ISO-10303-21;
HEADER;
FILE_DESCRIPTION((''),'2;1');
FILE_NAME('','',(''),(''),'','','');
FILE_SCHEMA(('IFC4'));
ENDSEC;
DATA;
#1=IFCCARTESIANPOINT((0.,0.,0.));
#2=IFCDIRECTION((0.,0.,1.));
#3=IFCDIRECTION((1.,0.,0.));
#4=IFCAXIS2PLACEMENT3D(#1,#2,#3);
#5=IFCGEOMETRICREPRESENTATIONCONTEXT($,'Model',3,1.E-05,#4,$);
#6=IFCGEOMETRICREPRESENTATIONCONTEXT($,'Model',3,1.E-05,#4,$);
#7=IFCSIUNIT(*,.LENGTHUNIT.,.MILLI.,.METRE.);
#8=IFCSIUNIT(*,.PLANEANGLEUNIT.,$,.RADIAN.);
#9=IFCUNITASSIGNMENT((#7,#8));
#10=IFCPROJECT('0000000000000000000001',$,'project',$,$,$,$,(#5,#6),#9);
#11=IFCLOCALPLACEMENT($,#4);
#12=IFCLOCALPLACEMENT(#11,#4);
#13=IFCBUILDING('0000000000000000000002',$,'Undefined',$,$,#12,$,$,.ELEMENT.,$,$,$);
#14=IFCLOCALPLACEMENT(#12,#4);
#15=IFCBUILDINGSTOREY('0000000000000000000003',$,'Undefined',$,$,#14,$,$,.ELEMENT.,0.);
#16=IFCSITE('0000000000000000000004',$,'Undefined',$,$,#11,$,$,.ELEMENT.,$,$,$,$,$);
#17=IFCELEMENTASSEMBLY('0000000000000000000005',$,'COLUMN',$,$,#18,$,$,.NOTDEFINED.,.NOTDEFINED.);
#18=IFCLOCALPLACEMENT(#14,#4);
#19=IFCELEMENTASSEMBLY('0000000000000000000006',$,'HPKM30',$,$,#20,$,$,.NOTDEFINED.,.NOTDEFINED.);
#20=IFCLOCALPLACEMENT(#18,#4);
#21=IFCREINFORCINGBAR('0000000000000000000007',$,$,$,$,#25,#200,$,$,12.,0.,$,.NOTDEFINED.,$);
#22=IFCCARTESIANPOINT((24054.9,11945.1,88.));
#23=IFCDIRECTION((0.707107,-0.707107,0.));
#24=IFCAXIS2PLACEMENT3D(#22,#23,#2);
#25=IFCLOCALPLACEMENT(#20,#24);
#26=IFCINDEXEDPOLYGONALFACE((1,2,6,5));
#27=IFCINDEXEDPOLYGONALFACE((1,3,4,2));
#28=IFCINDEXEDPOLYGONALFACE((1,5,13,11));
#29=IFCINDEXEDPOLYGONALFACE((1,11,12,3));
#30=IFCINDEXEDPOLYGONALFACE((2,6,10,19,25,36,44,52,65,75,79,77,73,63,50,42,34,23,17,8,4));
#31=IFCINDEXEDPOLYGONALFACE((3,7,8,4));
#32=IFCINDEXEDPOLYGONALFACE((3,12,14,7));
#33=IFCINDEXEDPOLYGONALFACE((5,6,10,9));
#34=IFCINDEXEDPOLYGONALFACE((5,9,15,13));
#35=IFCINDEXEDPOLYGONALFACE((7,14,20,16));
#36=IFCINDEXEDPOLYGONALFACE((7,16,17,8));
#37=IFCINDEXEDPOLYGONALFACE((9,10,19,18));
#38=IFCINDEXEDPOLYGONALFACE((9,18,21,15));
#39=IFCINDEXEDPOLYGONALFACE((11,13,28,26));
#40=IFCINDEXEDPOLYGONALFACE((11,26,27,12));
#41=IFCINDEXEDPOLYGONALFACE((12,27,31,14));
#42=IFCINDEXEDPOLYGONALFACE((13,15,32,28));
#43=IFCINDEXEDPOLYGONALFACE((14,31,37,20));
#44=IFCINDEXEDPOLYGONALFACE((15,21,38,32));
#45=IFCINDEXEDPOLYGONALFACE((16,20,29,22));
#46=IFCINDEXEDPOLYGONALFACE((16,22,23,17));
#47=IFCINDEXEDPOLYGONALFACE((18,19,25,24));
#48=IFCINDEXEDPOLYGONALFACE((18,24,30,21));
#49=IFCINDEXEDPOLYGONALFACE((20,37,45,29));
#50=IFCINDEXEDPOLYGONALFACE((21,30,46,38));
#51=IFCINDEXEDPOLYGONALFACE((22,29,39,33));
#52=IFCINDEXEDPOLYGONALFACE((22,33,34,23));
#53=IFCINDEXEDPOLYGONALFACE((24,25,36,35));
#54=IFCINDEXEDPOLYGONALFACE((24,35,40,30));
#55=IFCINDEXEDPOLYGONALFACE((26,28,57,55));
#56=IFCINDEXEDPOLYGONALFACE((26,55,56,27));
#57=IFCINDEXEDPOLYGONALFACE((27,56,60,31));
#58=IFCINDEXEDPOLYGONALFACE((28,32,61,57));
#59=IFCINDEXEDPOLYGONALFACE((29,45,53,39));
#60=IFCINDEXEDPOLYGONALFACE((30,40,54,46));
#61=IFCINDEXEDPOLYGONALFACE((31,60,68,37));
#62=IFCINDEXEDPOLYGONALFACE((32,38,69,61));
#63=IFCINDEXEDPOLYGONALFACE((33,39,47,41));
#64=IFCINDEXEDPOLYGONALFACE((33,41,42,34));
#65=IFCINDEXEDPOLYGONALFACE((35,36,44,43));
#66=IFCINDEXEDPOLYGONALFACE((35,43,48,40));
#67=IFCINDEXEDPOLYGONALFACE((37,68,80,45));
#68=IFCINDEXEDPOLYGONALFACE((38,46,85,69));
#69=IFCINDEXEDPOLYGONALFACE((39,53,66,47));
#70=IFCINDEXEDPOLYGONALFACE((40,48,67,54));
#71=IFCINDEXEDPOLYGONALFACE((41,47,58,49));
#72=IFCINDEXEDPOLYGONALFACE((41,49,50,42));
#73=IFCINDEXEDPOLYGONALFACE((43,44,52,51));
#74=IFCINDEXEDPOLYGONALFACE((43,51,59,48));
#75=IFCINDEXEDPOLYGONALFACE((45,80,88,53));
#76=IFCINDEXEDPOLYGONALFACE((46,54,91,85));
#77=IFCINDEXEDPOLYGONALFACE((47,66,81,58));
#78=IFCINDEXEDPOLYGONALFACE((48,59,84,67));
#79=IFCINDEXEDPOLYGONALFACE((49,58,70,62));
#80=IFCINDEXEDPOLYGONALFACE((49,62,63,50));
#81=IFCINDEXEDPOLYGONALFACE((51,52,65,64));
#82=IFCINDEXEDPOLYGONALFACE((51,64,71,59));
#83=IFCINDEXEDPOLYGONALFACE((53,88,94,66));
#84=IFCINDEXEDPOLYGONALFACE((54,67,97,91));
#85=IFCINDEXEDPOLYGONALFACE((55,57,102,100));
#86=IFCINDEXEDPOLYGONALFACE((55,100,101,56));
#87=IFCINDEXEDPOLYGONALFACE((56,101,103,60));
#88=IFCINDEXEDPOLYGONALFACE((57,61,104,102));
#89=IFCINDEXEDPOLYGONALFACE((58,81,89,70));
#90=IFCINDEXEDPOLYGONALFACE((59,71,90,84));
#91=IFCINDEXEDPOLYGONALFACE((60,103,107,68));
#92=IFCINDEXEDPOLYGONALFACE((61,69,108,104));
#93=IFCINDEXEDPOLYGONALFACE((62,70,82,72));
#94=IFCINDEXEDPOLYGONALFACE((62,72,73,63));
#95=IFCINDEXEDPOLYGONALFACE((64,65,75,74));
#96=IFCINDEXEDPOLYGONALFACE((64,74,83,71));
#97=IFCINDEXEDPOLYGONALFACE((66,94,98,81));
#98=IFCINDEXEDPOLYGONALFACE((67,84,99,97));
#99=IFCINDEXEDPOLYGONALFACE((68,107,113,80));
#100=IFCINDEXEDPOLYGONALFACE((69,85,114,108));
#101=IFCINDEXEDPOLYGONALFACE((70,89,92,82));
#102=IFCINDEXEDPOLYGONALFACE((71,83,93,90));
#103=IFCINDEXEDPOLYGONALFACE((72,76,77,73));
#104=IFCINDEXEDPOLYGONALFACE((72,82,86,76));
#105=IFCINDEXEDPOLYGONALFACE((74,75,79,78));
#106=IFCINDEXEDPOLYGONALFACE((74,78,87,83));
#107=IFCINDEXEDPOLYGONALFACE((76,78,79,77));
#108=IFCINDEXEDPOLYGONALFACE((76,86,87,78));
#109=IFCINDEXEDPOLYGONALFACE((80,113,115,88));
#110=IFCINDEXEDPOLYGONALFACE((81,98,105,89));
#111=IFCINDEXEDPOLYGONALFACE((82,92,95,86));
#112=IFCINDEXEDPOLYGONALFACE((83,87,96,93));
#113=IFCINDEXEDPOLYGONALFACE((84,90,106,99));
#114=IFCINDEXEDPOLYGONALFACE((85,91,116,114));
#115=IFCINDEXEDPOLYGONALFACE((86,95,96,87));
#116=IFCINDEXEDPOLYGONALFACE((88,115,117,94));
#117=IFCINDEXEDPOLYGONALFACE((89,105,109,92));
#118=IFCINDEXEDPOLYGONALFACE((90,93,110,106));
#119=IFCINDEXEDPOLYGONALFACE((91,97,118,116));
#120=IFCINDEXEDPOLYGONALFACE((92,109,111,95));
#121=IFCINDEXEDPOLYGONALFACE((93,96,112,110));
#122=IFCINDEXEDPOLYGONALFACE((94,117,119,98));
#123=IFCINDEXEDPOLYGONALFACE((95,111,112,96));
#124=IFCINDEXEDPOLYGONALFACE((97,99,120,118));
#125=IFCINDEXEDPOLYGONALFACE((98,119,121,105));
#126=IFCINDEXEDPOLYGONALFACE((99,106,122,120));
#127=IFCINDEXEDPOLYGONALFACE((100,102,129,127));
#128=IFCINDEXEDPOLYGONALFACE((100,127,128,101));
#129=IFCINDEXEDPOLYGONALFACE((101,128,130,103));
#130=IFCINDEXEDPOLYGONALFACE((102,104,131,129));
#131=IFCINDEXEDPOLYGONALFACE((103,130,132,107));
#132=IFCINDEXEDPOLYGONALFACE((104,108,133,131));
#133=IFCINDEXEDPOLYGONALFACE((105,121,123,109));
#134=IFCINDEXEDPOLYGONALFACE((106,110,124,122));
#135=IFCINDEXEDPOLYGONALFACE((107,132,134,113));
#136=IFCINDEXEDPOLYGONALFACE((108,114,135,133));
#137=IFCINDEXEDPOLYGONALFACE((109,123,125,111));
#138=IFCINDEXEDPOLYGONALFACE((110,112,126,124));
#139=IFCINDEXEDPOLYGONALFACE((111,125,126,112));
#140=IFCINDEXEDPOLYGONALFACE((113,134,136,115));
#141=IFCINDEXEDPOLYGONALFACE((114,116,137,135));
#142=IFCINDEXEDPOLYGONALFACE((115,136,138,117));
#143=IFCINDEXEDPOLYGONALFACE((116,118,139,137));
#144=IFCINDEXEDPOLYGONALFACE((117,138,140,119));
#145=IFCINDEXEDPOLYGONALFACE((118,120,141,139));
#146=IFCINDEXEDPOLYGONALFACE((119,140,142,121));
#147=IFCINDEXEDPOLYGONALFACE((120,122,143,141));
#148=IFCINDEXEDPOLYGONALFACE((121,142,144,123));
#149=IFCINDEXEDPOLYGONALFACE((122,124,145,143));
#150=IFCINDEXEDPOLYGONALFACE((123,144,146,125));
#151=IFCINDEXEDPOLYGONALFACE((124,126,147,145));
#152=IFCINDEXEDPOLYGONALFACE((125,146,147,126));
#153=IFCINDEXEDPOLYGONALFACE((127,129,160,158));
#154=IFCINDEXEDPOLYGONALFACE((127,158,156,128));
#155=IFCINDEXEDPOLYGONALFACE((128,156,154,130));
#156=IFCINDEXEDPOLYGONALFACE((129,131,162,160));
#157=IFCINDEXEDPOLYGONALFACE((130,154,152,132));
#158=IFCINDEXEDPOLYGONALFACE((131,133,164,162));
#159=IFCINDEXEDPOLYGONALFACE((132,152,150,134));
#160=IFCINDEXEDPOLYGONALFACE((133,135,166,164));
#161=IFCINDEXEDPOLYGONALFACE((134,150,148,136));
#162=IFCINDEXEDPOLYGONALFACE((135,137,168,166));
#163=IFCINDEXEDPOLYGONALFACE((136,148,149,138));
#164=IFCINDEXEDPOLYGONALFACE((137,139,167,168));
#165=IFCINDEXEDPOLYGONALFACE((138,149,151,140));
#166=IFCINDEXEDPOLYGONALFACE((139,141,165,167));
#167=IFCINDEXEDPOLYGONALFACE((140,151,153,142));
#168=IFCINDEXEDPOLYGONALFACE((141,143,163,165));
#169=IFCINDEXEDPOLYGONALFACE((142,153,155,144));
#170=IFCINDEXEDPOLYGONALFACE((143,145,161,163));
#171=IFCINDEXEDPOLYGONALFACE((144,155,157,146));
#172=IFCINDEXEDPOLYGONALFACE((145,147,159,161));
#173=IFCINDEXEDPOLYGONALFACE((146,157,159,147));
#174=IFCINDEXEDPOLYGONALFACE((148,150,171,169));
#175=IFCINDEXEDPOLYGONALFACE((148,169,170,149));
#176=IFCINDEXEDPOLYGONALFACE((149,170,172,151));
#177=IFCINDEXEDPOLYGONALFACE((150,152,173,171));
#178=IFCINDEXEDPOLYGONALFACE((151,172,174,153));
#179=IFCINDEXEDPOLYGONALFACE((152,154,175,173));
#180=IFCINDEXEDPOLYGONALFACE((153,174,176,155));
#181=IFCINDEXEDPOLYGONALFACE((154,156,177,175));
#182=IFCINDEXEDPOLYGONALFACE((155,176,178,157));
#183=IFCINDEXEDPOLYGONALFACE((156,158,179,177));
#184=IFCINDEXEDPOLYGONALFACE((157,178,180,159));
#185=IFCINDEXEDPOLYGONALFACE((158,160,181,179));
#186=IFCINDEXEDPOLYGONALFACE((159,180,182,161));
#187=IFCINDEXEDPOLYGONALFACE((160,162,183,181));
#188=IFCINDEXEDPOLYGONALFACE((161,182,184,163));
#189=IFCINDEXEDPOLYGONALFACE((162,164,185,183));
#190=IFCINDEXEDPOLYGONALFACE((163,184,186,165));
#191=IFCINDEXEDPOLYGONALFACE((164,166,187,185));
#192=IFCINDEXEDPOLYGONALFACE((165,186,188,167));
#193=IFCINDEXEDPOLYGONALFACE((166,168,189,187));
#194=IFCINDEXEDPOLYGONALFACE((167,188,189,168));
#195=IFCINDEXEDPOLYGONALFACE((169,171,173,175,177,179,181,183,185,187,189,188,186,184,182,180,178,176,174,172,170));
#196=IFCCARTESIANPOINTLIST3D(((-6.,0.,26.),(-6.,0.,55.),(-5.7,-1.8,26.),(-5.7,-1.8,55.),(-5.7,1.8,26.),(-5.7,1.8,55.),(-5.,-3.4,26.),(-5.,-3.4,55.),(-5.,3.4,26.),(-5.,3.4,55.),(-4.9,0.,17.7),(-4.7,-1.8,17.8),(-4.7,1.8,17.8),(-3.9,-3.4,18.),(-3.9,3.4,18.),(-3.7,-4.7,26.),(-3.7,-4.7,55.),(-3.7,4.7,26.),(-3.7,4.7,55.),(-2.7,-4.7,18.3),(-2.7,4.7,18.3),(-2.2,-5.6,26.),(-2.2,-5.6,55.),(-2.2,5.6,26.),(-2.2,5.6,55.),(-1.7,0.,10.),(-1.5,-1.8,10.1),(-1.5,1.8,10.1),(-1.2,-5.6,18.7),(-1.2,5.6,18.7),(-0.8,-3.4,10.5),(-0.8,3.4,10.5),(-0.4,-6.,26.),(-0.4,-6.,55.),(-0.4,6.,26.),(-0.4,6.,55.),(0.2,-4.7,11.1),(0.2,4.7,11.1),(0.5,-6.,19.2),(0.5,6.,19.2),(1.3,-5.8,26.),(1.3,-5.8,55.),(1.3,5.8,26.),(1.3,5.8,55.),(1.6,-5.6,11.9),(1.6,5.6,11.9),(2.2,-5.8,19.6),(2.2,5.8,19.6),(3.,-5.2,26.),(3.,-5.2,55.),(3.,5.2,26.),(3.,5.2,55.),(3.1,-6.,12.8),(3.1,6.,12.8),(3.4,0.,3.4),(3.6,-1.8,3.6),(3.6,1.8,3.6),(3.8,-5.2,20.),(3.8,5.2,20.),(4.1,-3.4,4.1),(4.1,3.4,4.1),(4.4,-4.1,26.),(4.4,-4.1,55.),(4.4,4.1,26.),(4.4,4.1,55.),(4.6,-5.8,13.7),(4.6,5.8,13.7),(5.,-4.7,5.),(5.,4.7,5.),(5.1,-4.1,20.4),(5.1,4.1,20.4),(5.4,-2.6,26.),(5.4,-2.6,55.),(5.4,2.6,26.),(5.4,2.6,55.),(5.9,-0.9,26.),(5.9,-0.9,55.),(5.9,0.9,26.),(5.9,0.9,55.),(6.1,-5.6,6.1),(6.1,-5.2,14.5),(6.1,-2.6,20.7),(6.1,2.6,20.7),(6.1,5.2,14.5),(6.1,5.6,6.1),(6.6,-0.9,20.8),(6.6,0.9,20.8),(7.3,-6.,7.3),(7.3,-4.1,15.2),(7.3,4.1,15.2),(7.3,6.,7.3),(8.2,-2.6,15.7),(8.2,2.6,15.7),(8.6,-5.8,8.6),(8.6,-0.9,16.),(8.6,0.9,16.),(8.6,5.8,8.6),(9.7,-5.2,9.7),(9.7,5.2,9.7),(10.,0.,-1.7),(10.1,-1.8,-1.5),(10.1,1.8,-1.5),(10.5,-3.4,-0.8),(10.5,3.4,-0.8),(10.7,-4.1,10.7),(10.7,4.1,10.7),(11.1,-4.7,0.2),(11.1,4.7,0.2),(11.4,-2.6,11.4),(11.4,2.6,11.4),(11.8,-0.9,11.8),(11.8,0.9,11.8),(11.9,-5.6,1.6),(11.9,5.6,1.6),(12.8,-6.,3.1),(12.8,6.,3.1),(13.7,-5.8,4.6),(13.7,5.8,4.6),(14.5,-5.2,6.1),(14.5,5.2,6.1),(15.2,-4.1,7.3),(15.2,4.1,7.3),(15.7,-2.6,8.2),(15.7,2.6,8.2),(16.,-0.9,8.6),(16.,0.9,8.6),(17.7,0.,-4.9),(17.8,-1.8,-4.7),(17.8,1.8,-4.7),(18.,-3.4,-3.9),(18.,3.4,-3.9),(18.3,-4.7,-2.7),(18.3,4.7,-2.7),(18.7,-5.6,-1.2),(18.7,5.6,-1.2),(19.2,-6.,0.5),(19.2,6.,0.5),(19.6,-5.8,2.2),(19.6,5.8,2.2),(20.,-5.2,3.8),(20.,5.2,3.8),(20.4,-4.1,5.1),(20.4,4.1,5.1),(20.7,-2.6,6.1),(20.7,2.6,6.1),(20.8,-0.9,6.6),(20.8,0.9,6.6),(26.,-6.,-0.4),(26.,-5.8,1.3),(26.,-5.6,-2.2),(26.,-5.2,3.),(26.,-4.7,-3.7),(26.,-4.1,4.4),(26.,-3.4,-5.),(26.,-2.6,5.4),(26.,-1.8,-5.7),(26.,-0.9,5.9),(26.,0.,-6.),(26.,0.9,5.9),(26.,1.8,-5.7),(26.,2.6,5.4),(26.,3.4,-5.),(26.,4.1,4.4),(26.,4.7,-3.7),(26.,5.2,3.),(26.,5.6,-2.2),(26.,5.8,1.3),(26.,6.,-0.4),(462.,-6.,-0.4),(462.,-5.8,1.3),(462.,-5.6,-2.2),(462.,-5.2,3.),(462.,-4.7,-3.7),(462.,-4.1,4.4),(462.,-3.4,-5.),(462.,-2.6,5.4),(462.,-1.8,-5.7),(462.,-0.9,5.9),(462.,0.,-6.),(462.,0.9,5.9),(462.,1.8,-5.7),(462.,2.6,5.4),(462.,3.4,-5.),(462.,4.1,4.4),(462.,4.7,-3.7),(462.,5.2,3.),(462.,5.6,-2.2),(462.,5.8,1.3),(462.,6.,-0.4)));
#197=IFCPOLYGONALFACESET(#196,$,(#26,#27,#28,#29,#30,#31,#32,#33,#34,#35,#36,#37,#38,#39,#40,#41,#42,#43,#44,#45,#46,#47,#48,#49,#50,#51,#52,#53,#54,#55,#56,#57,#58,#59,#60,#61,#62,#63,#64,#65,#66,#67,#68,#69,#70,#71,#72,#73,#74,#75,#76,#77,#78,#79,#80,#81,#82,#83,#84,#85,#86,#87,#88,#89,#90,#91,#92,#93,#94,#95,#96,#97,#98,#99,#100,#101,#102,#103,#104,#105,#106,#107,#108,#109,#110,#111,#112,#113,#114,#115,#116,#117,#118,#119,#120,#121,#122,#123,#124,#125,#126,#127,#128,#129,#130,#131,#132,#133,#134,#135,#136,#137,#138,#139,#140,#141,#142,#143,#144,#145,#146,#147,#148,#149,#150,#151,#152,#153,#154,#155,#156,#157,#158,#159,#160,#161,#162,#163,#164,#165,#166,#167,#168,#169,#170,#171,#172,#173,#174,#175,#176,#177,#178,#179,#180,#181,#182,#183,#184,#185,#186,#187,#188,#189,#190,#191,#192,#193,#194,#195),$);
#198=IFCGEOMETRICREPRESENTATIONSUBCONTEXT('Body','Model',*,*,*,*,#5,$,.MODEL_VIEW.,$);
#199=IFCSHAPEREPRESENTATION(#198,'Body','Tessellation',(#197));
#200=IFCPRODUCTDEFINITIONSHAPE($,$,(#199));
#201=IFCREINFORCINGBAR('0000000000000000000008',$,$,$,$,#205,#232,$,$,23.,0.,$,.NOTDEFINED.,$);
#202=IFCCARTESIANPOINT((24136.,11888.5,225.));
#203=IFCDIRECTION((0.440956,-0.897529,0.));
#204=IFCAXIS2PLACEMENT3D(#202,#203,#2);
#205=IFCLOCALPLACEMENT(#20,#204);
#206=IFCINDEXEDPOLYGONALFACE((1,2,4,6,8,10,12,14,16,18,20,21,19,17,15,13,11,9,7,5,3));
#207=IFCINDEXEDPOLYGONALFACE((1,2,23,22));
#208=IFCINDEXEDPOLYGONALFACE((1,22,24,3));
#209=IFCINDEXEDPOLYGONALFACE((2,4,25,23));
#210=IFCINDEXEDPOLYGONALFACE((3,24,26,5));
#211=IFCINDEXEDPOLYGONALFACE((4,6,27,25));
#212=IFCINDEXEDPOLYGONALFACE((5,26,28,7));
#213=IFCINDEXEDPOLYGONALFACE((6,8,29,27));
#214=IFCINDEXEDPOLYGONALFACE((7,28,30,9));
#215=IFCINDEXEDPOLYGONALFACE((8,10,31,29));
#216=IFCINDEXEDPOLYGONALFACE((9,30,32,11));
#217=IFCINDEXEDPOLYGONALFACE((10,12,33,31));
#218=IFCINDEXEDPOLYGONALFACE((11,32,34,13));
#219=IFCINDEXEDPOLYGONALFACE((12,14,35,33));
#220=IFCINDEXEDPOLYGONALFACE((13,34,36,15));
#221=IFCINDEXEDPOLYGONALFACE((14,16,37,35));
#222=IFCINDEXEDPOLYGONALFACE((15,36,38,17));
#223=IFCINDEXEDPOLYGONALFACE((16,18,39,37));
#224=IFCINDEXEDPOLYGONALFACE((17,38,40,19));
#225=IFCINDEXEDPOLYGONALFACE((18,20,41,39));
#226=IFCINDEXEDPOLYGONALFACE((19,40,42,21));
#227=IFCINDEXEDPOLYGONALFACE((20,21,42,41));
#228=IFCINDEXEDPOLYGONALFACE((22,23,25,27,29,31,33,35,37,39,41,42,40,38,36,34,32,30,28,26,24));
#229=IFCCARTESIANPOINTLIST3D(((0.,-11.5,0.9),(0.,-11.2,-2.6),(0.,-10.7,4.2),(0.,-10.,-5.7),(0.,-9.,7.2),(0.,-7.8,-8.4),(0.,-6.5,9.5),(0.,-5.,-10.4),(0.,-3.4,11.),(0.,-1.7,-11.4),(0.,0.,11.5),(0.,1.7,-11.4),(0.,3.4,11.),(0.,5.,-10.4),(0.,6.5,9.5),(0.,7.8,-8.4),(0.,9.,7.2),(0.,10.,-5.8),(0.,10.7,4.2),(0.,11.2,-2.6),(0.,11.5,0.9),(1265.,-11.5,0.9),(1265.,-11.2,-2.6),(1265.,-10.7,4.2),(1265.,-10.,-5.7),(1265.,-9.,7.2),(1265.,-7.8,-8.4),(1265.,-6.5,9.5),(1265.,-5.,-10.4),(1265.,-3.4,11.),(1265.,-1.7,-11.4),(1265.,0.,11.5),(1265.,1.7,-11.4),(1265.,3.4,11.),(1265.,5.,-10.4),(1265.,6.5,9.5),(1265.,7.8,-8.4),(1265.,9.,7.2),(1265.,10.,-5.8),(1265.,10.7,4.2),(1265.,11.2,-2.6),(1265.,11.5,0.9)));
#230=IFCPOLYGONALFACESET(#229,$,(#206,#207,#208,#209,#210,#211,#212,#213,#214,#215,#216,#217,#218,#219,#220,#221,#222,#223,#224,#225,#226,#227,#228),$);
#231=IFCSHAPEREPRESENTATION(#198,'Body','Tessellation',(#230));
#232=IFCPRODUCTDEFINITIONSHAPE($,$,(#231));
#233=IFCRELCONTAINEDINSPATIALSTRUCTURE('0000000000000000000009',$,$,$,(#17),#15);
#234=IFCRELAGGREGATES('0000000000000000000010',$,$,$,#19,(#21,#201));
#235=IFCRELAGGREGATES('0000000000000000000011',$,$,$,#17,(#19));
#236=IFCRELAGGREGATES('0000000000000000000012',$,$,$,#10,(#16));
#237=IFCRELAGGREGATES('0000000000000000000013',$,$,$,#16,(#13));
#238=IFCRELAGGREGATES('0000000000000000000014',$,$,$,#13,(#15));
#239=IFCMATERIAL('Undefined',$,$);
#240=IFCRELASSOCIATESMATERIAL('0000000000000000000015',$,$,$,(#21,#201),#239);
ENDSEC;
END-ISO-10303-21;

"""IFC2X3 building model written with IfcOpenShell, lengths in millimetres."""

from ifc_helpers import new_model, entity, si_unit, frame, origin_with_axes, place, context, subcontext, project, spatial, source, transform, mapped, material, element, aggregate, save


model = new_model("IFC2X3")

# Units and contexts
model_context_1 = context("Model", 3, precision=1e-05, world=origin_with_axes())
model_context_2 = context("Model", 3, precision=1e-05, world=origin_with_axes())
body_context = subcontext(model_context_1, "Body", "Model", "MODEL_VIEW")
ifc_project = project(units=[si_unit("LENGTHUNIT", "METRE", prefix="MILLI"), si_unit("PLANEANGLEUNIT", "RADIAN")], contexts=[model_context_1, model_context_2])

# Site, building, storey
site_placement = place(None, origin_with_axes())
site = spatial("IfcSite", under=ifc_project, at=site_placement, Name="Undefined", CompositionType="ELEMENT")
building_placement = place(site_placement, origin_with_axes())
building = spatial("IfcBuilding", under=site, at=building_placement, Name="Undefined", CompositionType="ELEMENT")
storey_placement = place(building_placement, origin_with_axes())
storey = spatial("IfcBuildingStorey", under=building, at=storey_placement, Name="Undefined", CompositionType="ELEMENT", Elevation=0.0)

# Element assembly
assembly_1_placement = place(storey_placement, origin_with_axes())
assembly_1 = element("IfcElementAssembly", 1, at=assembly_1_placement, inside=storey, Name="COLUMN", AssemblyPlace="NOTDEFINED", PredefinedType="NOTDEFINED")

# Element assembly
assembly_2_placement = place(assembly_1_placement, origin_with_axes())
assembly_2 = element("IfcElementAssembly", 2, at=assembly_2_placement, Name="HPKM30", AssemblyPlace="NOTDEFINED", PredefinedType="NOTDEFINED")

# Shared definitions
ifc_material_1 = material(Name="Undefined")

# Reinforcing bars
shared_shape_1 = source(origin_with_axes(), body_context, "Body", "AdvancedSweptSolid", [
    entity("IfcSweptDiskSolid", entity("IfcCompositeCurve", [entity("IfcCompositeCurveSegment", "CONTINUOUS", True, entity("IfcTrimmedCurve", entity("IfcLine", entity("IfcCartesianPoint", [0.0, 0.0, 0.0]), entity("IfcVector", entity("IfcDirection", [0.0, 0.0, -1.0]), 1.0)), [entity("IfcParameterValue", 0.0)], [entity("IfcParameterValue", 29.0)], True, "PARAMETER")), entity("IfcCompositeCurveSegment", "CONTINUOUS", True, entity("IfcTrimmedCurve", entity("IfcCircle", entity("IfcAxis2Placement3D", entity("IfcCartesianPoint", [26.0, 0.0, -29.0]), entity("IfcDirection", [0.0, -1.0, 0.0]), entity("IfcDirection", [-1.0, 0.0, 0.0])), 26.0), [entity("IfcParameterValue", 0.0)], [entity("IfcParameterValue", 1.570796)], True, "PARAMETER")), entity("IfcCompositeCurveSegment", "DISCONTINUOUS", True, entity("IfcTrimmedCurve", entity("IfcLine", entity("IfcCartesianPoint", [26.0, 0.0, -55.0]), entity("IfcVector", entity("IfcDirection", [1.0, 0.0, 0.0]), 1.0)), [entity("IfcParameterValue", 0.0)], [entity("IfcParameterValue", 436.0)], True, "PARAMETER"))], False), 6.0, None, 0.0, 466.6),
])
reinforcing_bar_1_placement = place(assembly_2_placement, frame((24054.9, 11945.1, 88.0), z_axis=(0.707107, -0.707107, 0.0), x_axis=(0.0, 0.0, 1.0)))
reinforcing_bar_1 = element("IfcReinforcingBar", 3, at=reinforcing_bar_1_placement, material=ifc_material_1, BarRole="NOTDEFINED", CrossSectionArea=0.0, NominalDiameter=12.0, context=body_context, shape_type="MappedRepresentation", body=[
    mapped(shared_shape_1, transform((0.0, 0.0, 55.0))),
])
shared_shape_2 = source(origin_with_axes(), body_context, "Body", "AdvancedSweptSolid", [
    entity("IfcSweptDiskSolid", entity("IfcTrimmedCurve", entity("IfcLine", entity("IfcCartesianPoint", [0.0, 0.0, 0.0]), entity("IfcVector", entity("IfcDirection", [1.0, 0.0, 0.0]), 1.0)), [entity("IfcParameterValue", 0.0)], [entity("IfcParameterValue", 1265.0)], True, "PARAMETER"), 11.5, None, 0.0, 1265.0),
])
reinforcing_bar_2_placement = place(assembly_2_placement, frame((24136.0, 11888.5, 225.0), z_axis=(0.440956, -0.897529, 0.0), x_axis=(0.0, 0.0, 1.0)))
reinforcing_bar_2 = element("IfcReinforcingBar", 4, at=reinforcing_bar_2_placement, material=ifc_material_1, BarRole="NOTDEFINED", CrossSectionArea=0.0, NominalDiameter=23.0, context=body_context, shape_type="MappedRepresentation", body=[
    mapped(shared_shape_2, transform((0.0, 0.0, 0.0))),
])
aggregate(assembly_2, [reinforcing_bar_1, reinforcing_bar_2])
aggregate(assembly_1, [assembly_2])

save(model, "model.ifc")
